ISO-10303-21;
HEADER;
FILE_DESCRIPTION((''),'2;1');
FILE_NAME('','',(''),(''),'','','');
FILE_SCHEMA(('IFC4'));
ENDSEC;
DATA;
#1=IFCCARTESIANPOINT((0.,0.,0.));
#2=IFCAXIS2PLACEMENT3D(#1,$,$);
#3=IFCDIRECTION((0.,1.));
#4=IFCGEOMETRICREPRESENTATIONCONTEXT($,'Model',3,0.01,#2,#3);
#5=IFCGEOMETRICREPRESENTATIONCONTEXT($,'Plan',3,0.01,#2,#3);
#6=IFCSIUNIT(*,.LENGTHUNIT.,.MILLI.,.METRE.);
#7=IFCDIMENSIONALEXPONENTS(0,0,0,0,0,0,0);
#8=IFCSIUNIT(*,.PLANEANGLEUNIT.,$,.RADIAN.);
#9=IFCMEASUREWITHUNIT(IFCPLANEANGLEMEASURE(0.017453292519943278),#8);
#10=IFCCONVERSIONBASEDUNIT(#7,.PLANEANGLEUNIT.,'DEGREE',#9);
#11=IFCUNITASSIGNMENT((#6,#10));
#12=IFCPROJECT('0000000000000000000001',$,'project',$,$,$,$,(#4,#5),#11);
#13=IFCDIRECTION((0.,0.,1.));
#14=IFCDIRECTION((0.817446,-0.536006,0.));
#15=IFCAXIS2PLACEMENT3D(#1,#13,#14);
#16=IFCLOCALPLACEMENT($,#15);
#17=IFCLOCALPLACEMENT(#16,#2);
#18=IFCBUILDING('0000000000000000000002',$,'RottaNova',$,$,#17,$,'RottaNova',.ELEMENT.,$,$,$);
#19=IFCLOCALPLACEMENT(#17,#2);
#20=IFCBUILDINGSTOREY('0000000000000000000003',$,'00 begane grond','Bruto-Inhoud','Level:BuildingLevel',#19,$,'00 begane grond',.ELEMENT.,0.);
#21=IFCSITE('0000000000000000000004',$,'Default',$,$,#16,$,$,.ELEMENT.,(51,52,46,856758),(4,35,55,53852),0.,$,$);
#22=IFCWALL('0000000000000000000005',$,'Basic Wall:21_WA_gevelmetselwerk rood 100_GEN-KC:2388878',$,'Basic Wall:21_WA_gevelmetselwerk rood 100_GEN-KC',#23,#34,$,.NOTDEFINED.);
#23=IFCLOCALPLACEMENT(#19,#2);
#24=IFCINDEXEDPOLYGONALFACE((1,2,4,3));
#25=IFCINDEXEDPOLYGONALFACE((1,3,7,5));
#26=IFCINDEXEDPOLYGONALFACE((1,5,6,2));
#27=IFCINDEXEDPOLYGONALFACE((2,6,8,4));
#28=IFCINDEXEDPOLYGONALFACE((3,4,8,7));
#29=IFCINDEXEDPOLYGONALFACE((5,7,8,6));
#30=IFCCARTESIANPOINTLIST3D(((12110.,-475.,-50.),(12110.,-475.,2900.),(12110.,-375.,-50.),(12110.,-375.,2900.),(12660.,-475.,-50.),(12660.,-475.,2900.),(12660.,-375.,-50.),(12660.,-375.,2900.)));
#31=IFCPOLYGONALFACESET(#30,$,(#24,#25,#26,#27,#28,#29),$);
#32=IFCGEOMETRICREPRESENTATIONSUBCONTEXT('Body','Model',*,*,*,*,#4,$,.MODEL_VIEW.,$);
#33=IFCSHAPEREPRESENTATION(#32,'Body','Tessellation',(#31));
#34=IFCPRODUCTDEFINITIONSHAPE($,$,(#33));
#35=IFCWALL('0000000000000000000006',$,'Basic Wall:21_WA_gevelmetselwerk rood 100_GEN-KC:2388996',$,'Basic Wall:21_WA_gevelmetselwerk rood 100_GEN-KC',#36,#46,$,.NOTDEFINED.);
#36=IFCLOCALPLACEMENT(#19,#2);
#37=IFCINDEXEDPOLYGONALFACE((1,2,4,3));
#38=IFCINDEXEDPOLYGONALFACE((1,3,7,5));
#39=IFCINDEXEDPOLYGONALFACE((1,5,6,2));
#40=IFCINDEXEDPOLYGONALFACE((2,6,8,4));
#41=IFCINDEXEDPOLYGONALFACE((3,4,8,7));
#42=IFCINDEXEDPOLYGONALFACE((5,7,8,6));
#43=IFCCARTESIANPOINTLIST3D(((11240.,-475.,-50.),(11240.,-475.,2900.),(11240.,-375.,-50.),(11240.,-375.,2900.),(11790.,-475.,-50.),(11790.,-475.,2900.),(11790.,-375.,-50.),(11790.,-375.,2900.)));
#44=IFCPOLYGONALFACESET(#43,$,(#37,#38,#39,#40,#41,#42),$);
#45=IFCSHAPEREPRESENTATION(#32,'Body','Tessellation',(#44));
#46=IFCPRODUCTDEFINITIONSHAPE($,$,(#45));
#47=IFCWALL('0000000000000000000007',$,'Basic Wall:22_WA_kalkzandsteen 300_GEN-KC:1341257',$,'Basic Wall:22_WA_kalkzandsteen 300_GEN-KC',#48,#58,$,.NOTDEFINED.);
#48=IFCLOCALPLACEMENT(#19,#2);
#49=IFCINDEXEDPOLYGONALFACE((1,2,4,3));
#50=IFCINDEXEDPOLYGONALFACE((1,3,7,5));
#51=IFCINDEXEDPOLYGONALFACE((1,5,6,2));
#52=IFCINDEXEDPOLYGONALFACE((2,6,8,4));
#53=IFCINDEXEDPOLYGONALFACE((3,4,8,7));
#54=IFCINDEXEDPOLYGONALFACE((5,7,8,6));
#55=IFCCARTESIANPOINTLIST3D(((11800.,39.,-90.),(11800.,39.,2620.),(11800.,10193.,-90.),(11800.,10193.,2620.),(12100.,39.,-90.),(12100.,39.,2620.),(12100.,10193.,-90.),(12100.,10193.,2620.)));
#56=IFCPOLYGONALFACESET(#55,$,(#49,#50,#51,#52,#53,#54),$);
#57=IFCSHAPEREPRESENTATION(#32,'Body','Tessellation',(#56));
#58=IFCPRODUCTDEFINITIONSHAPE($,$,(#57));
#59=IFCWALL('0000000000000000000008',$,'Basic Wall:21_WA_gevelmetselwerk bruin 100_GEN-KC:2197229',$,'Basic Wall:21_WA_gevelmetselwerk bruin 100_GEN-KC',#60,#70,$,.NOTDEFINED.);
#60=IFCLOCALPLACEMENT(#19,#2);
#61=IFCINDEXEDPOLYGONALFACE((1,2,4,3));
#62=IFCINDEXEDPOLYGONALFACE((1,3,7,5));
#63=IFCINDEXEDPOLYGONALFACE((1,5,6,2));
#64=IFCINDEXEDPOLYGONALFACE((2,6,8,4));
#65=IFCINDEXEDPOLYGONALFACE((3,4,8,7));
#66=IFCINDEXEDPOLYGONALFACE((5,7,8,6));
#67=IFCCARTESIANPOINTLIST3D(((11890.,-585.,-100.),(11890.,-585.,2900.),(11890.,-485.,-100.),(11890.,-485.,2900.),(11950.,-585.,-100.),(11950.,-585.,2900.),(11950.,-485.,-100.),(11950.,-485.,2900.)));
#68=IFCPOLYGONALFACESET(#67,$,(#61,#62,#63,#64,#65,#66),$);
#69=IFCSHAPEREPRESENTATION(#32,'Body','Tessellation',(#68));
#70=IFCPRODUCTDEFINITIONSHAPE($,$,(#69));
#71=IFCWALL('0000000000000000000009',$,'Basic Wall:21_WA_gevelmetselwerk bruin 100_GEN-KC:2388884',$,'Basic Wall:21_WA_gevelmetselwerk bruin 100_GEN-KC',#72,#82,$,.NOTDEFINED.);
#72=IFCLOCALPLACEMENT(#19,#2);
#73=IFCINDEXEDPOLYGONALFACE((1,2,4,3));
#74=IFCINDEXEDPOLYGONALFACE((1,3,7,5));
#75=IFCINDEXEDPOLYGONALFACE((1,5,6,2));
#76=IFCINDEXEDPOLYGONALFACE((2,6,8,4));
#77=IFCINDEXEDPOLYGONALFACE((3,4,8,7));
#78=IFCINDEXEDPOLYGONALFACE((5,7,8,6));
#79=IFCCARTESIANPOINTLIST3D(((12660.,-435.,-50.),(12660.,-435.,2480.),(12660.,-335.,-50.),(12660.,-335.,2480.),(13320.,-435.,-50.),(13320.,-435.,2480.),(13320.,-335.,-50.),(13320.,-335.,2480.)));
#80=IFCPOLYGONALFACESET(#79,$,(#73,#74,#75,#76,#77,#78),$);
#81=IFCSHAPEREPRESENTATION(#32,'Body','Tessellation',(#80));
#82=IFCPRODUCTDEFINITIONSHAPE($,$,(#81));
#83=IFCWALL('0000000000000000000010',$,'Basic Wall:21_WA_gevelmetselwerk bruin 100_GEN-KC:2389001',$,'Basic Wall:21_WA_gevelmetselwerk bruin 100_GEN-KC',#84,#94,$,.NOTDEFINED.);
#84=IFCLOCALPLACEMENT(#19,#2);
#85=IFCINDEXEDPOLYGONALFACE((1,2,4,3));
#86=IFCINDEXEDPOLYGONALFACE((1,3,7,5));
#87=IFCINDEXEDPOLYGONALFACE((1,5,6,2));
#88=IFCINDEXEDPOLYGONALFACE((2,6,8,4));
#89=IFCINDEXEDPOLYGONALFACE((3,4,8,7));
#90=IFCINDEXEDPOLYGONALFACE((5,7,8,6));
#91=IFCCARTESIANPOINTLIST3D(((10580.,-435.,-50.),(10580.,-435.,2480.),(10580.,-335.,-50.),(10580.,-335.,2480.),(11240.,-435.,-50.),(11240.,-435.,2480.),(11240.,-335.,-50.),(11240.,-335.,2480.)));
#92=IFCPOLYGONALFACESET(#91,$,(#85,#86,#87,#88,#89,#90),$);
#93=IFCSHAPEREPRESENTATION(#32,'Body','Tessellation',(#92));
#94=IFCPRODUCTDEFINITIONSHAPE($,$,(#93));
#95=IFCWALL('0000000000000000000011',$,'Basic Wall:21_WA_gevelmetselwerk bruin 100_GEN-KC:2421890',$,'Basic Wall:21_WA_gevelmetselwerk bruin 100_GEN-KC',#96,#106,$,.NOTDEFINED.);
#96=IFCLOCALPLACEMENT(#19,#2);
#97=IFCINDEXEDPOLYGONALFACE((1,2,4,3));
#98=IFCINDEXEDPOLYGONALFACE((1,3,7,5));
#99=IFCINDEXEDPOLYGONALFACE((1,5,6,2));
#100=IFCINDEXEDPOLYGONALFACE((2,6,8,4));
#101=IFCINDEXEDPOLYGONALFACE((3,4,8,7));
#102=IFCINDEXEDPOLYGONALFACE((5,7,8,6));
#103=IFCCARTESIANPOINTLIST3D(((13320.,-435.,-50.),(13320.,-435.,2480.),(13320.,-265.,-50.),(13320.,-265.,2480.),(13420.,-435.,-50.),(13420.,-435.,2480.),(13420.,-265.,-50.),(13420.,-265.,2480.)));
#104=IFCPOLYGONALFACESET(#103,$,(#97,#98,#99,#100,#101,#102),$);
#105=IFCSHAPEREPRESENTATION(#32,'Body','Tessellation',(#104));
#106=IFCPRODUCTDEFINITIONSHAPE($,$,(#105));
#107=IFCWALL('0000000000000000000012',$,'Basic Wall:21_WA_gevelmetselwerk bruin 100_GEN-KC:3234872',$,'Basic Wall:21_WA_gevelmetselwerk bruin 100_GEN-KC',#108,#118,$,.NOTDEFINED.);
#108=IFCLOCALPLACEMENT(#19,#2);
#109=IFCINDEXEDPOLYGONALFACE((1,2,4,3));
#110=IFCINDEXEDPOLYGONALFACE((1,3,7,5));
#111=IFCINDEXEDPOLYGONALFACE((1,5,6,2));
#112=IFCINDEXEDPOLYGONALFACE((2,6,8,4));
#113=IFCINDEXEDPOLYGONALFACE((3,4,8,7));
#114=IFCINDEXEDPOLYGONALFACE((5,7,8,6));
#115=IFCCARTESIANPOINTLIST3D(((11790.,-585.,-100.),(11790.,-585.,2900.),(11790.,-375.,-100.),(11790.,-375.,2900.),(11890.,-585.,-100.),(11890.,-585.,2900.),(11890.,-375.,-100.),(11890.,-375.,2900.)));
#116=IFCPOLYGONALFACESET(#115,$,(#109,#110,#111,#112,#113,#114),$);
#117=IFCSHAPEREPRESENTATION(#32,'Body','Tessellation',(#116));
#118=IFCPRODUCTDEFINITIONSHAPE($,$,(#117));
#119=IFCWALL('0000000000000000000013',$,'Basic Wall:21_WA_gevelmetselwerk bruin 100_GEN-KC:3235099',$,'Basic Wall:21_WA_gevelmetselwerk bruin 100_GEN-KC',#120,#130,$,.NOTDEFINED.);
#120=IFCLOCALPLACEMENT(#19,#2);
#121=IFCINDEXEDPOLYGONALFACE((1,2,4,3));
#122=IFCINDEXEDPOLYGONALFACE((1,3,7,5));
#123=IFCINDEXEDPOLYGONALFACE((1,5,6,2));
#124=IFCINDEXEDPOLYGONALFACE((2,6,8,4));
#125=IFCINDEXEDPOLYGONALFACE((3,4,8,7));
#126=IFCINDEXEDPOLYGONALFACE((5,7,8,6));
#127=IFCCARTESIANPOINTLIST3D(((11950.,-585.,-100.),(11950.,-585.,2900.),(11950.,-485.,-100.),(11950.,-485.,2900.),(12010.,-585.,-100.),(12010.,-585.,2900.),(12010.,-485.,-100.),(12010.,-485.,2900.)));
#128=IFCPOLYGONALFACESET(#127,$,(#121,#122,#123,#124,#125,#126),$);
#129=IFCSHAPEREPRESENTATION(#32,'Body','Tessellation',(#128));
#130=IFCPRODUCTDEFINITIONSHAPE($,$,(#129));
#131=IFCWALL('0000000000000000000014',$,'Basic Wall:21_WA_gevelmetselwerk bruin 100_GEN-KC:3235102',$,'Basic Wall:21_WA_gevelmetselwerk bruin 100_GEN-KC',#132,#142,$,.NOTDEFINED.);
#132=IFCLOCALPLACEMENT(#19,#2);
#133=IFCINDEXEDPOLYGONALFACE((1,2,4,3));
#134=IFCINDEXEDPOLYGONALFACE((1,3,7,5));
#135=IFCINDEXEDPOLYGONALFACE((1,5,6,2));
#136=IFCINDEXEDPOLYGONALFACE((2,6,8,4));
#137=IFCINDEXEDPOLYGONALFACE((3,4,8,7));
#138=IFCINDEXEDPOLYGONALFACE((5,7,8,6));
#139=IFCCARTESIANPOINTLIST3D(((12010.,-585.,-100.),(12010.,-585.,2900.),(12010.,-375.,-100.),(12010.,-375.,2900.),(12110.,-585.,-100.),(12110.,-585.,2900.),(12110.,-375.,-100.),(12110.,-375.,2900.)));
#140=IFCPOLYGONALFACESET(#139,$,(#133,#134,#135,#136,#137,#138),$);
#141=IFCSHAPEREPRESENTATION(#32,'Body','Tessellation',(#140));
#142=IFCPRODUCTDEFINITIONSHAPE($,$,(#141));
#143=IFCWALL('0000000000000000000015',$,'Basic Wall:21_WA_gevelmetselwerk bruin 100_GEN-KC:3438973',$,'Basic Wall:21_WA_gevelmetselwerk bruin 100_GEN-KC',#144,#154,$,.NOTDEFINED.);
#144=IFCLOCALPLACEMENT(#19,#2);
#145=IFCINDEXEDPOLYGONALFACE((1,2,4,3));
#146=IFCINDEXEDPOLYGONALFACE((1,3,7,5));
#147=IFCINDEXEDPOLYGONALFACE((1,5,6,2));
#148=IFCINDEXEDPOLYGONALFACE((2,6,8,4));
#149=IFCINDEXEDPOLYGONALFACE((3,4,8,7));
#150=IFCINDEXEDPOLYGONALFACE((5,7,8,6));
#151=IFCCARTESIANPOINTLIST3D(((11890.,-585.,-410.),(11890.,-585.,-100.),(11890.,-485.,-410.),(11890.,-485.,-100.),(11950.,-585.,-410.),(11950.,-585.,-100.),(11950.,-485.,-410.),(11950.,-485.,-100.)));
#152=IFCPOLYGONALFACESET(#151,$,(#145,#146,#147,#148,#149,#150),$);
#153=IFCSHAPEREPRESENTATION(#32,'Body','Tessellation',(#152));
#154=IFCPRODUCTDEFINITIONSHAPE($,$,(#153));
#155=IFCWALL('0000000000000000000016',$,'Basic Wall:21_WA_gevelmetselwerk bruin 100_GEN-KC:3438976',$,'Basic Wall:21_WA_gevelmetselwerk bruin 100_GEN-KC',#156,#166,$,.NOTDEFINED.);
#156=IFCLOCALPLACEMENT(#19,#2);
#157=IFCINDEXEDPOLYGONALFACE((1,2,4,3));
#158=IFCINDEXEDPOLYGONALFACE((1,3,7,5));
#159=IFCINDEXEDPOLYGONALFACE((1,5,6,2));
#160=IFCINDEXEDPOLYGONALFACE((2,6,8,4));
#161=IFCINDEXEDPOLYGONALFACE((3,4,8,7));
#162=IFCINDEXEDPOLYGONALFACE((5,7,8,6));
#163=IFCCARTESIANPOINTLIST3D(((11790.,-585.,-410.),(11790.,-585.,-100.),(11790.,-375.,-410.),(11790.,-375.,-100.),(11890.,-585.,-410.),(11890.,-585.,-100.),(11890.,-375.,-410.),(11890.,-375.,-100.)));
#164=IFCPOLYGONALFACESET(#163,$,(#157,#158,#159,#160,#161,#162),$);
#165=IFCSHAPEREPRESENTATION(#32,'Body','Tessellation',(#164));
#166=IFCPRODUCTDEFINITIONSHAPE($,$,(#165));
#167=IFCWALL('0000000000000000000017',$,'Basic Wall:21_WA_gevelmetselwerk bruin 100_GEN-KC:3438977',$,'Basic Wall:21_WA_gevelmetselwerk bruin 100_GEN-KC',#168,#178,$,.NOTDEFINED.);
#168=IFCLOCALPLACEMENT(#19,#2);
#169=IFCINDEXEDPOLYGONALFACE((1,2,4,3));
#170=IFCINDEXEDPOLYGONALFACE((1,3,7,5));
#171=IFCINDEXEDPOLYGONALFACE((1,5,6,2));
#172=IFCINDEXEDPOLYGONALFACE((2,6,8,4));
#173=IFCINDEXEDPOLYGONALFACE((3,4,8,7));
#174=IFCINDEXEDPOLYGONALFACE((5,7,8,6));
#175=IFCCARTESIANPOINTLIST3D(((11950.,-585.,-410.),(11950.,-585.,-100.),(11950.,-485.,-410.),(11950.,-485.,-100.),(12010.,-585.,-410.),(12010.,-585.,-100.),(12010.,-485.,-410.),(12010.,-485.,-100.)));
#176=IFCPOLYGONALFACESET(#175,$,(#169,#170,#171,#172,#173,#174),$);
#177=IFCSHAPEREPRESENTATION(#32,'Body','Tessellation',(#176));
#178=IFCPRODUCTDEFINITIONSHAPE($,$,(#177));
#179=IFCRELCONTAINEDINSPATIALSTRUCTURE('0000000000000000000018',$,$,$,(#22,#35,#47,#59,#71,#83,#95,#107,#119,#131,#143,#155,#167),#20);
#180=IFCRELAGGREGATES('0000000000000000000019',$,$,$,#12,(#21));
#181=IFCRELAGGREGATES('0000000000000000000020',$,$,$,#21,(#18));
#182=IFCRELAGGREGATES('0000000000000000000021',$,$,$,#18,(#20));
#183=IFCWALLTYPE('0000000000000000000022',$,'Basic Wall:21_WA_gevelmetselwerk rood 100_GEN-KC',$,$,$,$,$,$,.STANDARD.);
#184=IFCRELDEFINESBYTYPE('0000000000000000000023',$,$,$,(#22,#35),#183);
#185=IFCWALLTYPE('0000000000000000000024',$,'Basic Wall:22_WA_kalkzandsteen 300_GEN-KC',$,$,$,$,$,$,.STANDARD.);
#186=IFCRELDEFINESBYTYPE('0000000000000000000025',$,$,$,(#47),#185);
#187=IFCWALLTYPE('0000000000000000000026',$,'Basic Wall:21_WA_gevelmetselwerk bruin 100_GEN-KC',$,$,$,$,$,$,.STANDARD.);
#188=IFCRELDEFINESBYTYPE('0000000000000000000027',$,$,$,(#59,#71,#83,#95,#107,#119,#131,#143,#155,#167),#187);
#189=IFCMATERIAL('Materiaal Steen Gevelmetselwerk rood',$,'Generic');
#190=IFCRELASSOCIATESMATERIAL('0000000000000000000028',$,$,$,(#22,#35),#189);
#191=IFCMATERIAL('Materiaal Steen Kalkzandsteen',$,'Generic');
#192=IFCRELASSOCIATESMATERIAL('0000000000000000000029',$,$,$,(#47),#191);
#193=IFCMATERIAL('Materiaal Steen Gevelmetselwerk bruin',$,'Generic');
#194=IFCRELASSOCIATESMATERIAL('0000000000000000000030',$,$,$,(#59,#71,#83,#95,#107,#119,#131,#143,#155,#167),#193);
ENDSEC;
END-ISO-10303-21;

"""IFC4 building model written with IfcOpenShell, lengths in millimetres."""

from ifc_helpers import new_model, entity, si_unit, converted_unit, direction, frame, origin, place, context, subcontext, project, spatial, indexed_curve, outline, extrude, material, type_object, element, save


model = new_model("IFC4")

# Units and contexts
model_context = context("Model", 3, precision=0.01, world=origin(), true_north=direction((0.0, 1.0)))
plan_context = context("Plan", 3, precision=0.01, world=origin(), true_north=direction((0.0, 1.0)))
body_context = subcontext(model_context, "Body", "Model", "MODEL_VIEW")
ifc_project = project(units=[si_unit("LENGTHUNIT", "METRE", prefix="MILLI"), converted_unit("PLANEANGLEUNIT", "DEGREE", entity("IfcPlaneAngleMeasure", 0.017453292519943278), si_unit("PLANEANGLEUNIT", "RADIAN"), dimensions=[0, 0, 0, 0, 0, 0, 0])], contexts=[model_context, plan_context])

# Site, building, storey
site_placement = place(None, frame((0.0, 0.0, 0.0), z_axis=(0.0, 0.0, 1.0), x_axis=(0.817446, -0.536006, 0.0)))
site = spatial("IfcSite", under=ifc_project, at=site_placement, Name="Default", CompositionType="ELEMENT", RefLatitude=(51, 52, 46, 856758), RefLongitude=(4, 35, 55, 53852), RefElevation=0.0)
building_placement = place(site_placement, origin())
building = spatial("IfcBuilding", under=site, at=building_placement, Name="RottaNova", LongName="RottaNova", CompositionType="ELEMENT")
storey_placement = place(building_placement, origin())
storey = spatial("IfcBuildingStorey", under=building, at=storey_placement, Name="00 begane grond", Description="Bruto-Inhoud", ObjectType="Level:BuildingLevel", LongName="00 begane grond", CompositionType="ELEMENT", Elevation=0.0)

# Walls
ifc_material_1 = material(Name="Materiaal Steen Gevelmetselwerk rood", Category="Generic")
wall_type_1 = type_object("IfcWallType", Name="Basic Wall:21_WA_gevelmetselwerk rood 100_GEN-KC", PredefinedType="STANDARD")
wall_1_placement = place(storey_placement, frame((12660.0, -425.0, -50.0), z_axis=(0.0, 0.0, 1.0), x_axis=(-1.0, 0.0, 0.0)))
element("IfcWall", 1, at=wall_1_placement, inside=storey, type_object=wall_type_1, material=ifc_material_1, Name="Basic Wall:21_WA_gevelmetselwerk rood 100_GEN-KC:2388878", ObjectType="Basic Wall:21_WA_gevelmetselwerk rood 100_GEN-KC", PredefinedType="NOTDEFINED", context=body_context, shape_type="SweptSolid", body=[
    extrude(outline(indexed_curve([(550.0, 50.0), (0.0, 50.0), (0.0, -50.0), (550.0, -50.0), (550.0, 50.0)], self_intersect=False)), origin(), (0.0, 0.0, 1.0), 2950.0),
])
wall_2_placement = place(storey_placement, frame((11240.0, -425.0, -50.0)))
element("IfcWall", 2, at=wall_2_placement, inside=storey, type_object=wall_type_1, material=ifc_material_1, Name="Basic Wall:21_WA_gevelmetselwerk rood 100_GEN-KC:2388996", ObjectType="Basic Wall:21_WA_gevelmetselwerk rood 100_GEN-KC", PredefinedType="NOTDEFINED", context=body_context, shape_type="SweptSolid", body=[
    extrude(outline(indexed_curve([(550.0, 50.0), (0.0, 50.0), (0.0, -50.0), (550.0, -50.0), (550.0, 50.0)], self_intersect=False)), origin(), (0.0, 0.0, 1.0), 2950.0),
])
ifc_material_2 = material(Name="Materiaal Steen Kalkzandsteen", Category="Generic")
wall_type_2 = type_object("IfcWallType", Name="Basic Wall:22_WA_kalkzandsteen 300_GEN-KC", PredefinedType="STANDARD")
wall_3_placement = place(storey_placement, frame((11950.0, 39.0, -90.0), z_axis=(0.0, 0.0, 1.0), x_axis=(0.0, 1.0, 0.0)))
element("IfcWall", 3, at=wall_3_placement, inside=storey, type_object=wall_type_2, material=ifc_material_2, Name="Basic Wall:22_WA_kalkzandsteen 300_GEN-KC:1341257", ObjectType="Basic Wall:22_WA_kalkzandsteen 300_GEN-KC", PredefinedType="NOTDEFINED", context=body_context, shape_type="SweptSolid", body=[
    extrude(outline(indexed_curve([(10154.0, 150.0), (0.0, 150.0), (0.0, -150.0), (10154.0, -150.0), (10154.0, 150.0)], self_intersect=False)), origin(), (0.0, 0.0, 1.0), 2710.0),
])
ifc_material_3 = material(Name="Materiaal Steen Gevelmetselwerk bruin", Category="Generic")
wall_type_3 = type_object("IfcWallType", Name="Basic Wall:21_WA_gevelmetselwerk bruin 100_GEN-KC", PredefinedType="STANDARD")
wall_4_placement = place(storey_placement, frame((11890.0, -535.0, -100.0)))
element("IfcWall", 4, at=wall_4_placement, inside=storey, type_object=wall_type_3, material=ifc_material_3, Name="Basic Wall:21_WA_gevelmetselwerk bruin 100_GEN-KC:2197229", ObjectType="Basic Wall:21_WA_gevelmetselwerk bruin 100_GEN-KC", PredefinedType="NOTDEFINED", context=body_context, shape_type="SweptSolid", body=[
    extrude(outline(indexed_curve([(60.0, 50.0), (0.0, 50.0), (0.0, -50.0), (60.0, -50.0), (60.0, 50.0)], self_intersect=False)), origin(), (0.0, 0.0, 1.0), 3000.0),
])
wall_5_placement = place(storey_placement, frame((12660.0, -385.0, -50.0)))
element("IfcWall", 5, at=wall_5_placement, inside=storey, type_object=wall_type_3, material=ifc_material_3, Name="Basic Wall:21_WA_gevelmetselwerk bruin 100_GEN-KC:2388884", ObjectType="Basic Wall:21_WA_gevelmetselwerk bruin 100_GEN-KC", PredefinedType="NOTDEFINED", context=body_context, shape_type="SweptSolid", body=[
    extrude(outline(indexed_curve([(660.0, 50.0), (0.0, 50.0), (0.0, -50.0), (660.0, -50.0), (660.0, 50.0)], self_intersect=False)), origin(), (0.0, 0.0, 1.0), 2530.0),
])
wall_6_placement = place(storey_placement, frame((11240.0, -385.0, -50.0), z_axis=(0.0, 0.0, 1.0), x_axis=(-1.0, 0.0, 0.0)))
element("IfcWall", 6, at=wall_6_placement, inside=storey, type_object=wall_type_3, material=ifc_material_3, Name="Basic Wall:21_WA_gevelmetselwerk bruin 100_GEN-KC:2389001", ObjectType="Basic Wall:21_WA_gevelmetselwerk bruin 100_GEN-KC", PredefinedType="NOTDEFINED", context=body_context, shape_type="SweptSolid", body=[
    extrude(outline(indexed_curve([(660.0, 50.0), (0.0, 50.0), (0.0, -50.0), (660.0, -50.0), (660.0, 50.0)], self_intersect=False)), origin(), (0.0, 0.0, 1.0), 2530.0),
])
wall_7_placement = place(storey_placement, frame((13370.0, -265.0, -50.0), z_axis=(0.0, 0.0, 1.0), x_axis=(0.0, -1.0, 0.0)))
element("IfcWall", 7, at=wall_7_placement, inside=storey, type_object=wall_type_3, material=ifc_material_3, Name="Basic Wall:21_WA_gevelmetselwerk bruin 100_GEN-KC:2421890", ObjectType="Basic Wall:21_WA_gevelmetselwerk bruin 100_GEN-KC", PredefinedType="NOTDEFINED", context=body_context, shape_type="SweptSolid", body=[
    extrude(outline(indexed_curve([(170.0, 50.0), (0.0, 50.0), (0.0, -50.0), (170.0, -50.0), (170.0, 50.0)], self_intersect=False)), origin(), (0.0, 0.0, 1.0), 2530.0),
])
wall_8_placement = place(storey_placement, frame((11840.0, -585.0, -100.0), z_axis=(0.0, 0.0, 1.0), x_axis=(0.0, 1.0, 0.0)))
element("IfcWall", 8, at=wall_8_placement, inside=storey, type_object=wall_type_3, material=ifc_material_3, Name="Basic Wall:21_WA_gevelmetselwerk bruin 100_GEN-KC:3234872", ObjectType="Basic Wall:21_WA_gevelmetselwerk bruin 100_GEN-KC", PredefinedType="NOTDEFINED", context=body_context, shape_type="SweptSolid", body=[
    extrude(outline(indexed_curve([(210.0, 50.0), (0.0, 50.0), (0.0, -50.0), (210.0, -50.0), (210.0, 50.0)], self_intersect=False)), origin(), (0.0, 0.0, 1.0), 3000.0),
])
wall_9_placement = place(storey_placement, frame((12010.0, -535.0, -100.0), z_axis=(0.0, 0.0, 1.0), x_axis=(-1.0, 0.0, 0.0)))
element("IfcWall", 9, at=wall_9_placement, inside=storey, type_object=wall_type_3, material=ifc_material_3, Name="Basic Wall:21_WA_gevelmetselwerk bruin 100_GEN-KC:3235099", ObjectType="Basic Wall:21_WA_gevelmetselwerk bruin 100_GEN-KC", PredefinedType="NOTDEFINED", context=body_context, shape_type="SweptSolid", body=[
    extrude(outline(indexed_curve([(60.0, 50.0), (0.0, 50.0), (0.0, -50.0), (60.0, -50.0), (60.0, 50.0)], self_intersect=False)), origin(), (0.0, 0.0, 1.0), 3000.0),
])
wall_10_placement = place(storey_placement, frame((12060.0, -585.0, -100.0), z_axis=(0.0, 0.0, 1.0), x_axis=(0.0, 1.0, 0.0)))
element("IfcWall", 10, at=wall_10_placement, inside=storey, type_object=wall_type_3, material=ifc_material_3, Name="Basic Wall:21_WA_gevelmetselwerk bruin 100_GEN-KC:3235102", ObjectType="Basic Wall:21_WA_gevelmetselwerk bruin 100_GEN-KC", PredefinedType="NOTDEFINED", context=body_context, shape_type="SweptSolid", body=[
    extrude(outline(indexed_curve([(210.0, 50.0), (0.0, 50.0), (0.0, -50.0), (210.0, -50.0), (210.0, 50.0)], self_intersect=False)), origin(), (0.0, 0.0, 1.0), 3000.0),
])
wall_11_placement = place(storey_placement, frame((11890.0, -535.0, -410.0)))
element("IfcWall", 11, at=wall_11_placement, inside=storey, type_object=wall_type_3, material=ifc_material_3, Name="Basic Wall:21_WA_gevelmetselwerk bruin 100_GEN-KC:3438973", ObjectType="Basic Wall:21_WA_gevelmetselwerk bruin 100_GEN-KC", PredefinedType="NOTDEFINED", context=body_context, shape_type="SweptSolid", body=[
    extrude(outline(indexed_curve([(60.0, 50.0), (0.0, 50.0), (0.0, -50.0), (60.0, -50.0), (60.0, 50.0)], self_intersect=False)), origin(), (0.0, 0.0, 1.0), 310.0),
])
wall_12_placement = place(storey_placement, frame((11840.0, -585.0, -410.0), z_axis=(0.0, 0.0, 1.0), x_axis=(0.0, 1.0, 0.0)))
element("IfcWall", 12, at=wall_12_placement, inside=storey, type_object=wall_type_3, material=ifc_material_3, Name="Basic Wall:21_WA_gevelmetselwerk bruin 100_GEN-KC:3438976", ObjectType="Basic Wall:21_WA_gevelmetselwerk bruin 100_GEN-KC", PredefinedType="NOTDEFINED", context=body_context, shape_type="SweptSolid", body=[
    extrude(outline(indexed_curve([(210.0, 50.0), (0.0, 50.0), (0.0, -50.0), (210.0, -50.0), (210.0, 50.0)], self_intersect=False)), origin(), (0.0, 0.0, 1.0), 310.0),
])
wall_13_placement = place(storey_placement, frame((12010.0, -535.0, -410.0), z_axis=(0.0, 0.0, 1.0), x_axis=(-1.0, 0.0, 0.0)))
element("IfcWall", 13, at=wall_13_placement, inside=storey, type_object=wall_type_3, material=ifc_material_3, Name="Basic Wall:21_WA_gevelmetselwerk bruin 100_GEN-KC:3438977", ObjectType="Basic Wall:21_WA_gevelmetselwerk bruin 100_GEN-KC", PredefinedType="NOTDEFINED", context=body_context, shape_type="SweptSolid", body=[
    extrude(outline(indexed_curve([(60.0, 50.0), (0.0, 50.0), (0.0, -50.0), (60.0, -50.0), (60.0, 50.0)], self_intersect=False)), origin(), (0.0, 0.0, 1.0), 310.0),
])

save(model, "model.ifc")
